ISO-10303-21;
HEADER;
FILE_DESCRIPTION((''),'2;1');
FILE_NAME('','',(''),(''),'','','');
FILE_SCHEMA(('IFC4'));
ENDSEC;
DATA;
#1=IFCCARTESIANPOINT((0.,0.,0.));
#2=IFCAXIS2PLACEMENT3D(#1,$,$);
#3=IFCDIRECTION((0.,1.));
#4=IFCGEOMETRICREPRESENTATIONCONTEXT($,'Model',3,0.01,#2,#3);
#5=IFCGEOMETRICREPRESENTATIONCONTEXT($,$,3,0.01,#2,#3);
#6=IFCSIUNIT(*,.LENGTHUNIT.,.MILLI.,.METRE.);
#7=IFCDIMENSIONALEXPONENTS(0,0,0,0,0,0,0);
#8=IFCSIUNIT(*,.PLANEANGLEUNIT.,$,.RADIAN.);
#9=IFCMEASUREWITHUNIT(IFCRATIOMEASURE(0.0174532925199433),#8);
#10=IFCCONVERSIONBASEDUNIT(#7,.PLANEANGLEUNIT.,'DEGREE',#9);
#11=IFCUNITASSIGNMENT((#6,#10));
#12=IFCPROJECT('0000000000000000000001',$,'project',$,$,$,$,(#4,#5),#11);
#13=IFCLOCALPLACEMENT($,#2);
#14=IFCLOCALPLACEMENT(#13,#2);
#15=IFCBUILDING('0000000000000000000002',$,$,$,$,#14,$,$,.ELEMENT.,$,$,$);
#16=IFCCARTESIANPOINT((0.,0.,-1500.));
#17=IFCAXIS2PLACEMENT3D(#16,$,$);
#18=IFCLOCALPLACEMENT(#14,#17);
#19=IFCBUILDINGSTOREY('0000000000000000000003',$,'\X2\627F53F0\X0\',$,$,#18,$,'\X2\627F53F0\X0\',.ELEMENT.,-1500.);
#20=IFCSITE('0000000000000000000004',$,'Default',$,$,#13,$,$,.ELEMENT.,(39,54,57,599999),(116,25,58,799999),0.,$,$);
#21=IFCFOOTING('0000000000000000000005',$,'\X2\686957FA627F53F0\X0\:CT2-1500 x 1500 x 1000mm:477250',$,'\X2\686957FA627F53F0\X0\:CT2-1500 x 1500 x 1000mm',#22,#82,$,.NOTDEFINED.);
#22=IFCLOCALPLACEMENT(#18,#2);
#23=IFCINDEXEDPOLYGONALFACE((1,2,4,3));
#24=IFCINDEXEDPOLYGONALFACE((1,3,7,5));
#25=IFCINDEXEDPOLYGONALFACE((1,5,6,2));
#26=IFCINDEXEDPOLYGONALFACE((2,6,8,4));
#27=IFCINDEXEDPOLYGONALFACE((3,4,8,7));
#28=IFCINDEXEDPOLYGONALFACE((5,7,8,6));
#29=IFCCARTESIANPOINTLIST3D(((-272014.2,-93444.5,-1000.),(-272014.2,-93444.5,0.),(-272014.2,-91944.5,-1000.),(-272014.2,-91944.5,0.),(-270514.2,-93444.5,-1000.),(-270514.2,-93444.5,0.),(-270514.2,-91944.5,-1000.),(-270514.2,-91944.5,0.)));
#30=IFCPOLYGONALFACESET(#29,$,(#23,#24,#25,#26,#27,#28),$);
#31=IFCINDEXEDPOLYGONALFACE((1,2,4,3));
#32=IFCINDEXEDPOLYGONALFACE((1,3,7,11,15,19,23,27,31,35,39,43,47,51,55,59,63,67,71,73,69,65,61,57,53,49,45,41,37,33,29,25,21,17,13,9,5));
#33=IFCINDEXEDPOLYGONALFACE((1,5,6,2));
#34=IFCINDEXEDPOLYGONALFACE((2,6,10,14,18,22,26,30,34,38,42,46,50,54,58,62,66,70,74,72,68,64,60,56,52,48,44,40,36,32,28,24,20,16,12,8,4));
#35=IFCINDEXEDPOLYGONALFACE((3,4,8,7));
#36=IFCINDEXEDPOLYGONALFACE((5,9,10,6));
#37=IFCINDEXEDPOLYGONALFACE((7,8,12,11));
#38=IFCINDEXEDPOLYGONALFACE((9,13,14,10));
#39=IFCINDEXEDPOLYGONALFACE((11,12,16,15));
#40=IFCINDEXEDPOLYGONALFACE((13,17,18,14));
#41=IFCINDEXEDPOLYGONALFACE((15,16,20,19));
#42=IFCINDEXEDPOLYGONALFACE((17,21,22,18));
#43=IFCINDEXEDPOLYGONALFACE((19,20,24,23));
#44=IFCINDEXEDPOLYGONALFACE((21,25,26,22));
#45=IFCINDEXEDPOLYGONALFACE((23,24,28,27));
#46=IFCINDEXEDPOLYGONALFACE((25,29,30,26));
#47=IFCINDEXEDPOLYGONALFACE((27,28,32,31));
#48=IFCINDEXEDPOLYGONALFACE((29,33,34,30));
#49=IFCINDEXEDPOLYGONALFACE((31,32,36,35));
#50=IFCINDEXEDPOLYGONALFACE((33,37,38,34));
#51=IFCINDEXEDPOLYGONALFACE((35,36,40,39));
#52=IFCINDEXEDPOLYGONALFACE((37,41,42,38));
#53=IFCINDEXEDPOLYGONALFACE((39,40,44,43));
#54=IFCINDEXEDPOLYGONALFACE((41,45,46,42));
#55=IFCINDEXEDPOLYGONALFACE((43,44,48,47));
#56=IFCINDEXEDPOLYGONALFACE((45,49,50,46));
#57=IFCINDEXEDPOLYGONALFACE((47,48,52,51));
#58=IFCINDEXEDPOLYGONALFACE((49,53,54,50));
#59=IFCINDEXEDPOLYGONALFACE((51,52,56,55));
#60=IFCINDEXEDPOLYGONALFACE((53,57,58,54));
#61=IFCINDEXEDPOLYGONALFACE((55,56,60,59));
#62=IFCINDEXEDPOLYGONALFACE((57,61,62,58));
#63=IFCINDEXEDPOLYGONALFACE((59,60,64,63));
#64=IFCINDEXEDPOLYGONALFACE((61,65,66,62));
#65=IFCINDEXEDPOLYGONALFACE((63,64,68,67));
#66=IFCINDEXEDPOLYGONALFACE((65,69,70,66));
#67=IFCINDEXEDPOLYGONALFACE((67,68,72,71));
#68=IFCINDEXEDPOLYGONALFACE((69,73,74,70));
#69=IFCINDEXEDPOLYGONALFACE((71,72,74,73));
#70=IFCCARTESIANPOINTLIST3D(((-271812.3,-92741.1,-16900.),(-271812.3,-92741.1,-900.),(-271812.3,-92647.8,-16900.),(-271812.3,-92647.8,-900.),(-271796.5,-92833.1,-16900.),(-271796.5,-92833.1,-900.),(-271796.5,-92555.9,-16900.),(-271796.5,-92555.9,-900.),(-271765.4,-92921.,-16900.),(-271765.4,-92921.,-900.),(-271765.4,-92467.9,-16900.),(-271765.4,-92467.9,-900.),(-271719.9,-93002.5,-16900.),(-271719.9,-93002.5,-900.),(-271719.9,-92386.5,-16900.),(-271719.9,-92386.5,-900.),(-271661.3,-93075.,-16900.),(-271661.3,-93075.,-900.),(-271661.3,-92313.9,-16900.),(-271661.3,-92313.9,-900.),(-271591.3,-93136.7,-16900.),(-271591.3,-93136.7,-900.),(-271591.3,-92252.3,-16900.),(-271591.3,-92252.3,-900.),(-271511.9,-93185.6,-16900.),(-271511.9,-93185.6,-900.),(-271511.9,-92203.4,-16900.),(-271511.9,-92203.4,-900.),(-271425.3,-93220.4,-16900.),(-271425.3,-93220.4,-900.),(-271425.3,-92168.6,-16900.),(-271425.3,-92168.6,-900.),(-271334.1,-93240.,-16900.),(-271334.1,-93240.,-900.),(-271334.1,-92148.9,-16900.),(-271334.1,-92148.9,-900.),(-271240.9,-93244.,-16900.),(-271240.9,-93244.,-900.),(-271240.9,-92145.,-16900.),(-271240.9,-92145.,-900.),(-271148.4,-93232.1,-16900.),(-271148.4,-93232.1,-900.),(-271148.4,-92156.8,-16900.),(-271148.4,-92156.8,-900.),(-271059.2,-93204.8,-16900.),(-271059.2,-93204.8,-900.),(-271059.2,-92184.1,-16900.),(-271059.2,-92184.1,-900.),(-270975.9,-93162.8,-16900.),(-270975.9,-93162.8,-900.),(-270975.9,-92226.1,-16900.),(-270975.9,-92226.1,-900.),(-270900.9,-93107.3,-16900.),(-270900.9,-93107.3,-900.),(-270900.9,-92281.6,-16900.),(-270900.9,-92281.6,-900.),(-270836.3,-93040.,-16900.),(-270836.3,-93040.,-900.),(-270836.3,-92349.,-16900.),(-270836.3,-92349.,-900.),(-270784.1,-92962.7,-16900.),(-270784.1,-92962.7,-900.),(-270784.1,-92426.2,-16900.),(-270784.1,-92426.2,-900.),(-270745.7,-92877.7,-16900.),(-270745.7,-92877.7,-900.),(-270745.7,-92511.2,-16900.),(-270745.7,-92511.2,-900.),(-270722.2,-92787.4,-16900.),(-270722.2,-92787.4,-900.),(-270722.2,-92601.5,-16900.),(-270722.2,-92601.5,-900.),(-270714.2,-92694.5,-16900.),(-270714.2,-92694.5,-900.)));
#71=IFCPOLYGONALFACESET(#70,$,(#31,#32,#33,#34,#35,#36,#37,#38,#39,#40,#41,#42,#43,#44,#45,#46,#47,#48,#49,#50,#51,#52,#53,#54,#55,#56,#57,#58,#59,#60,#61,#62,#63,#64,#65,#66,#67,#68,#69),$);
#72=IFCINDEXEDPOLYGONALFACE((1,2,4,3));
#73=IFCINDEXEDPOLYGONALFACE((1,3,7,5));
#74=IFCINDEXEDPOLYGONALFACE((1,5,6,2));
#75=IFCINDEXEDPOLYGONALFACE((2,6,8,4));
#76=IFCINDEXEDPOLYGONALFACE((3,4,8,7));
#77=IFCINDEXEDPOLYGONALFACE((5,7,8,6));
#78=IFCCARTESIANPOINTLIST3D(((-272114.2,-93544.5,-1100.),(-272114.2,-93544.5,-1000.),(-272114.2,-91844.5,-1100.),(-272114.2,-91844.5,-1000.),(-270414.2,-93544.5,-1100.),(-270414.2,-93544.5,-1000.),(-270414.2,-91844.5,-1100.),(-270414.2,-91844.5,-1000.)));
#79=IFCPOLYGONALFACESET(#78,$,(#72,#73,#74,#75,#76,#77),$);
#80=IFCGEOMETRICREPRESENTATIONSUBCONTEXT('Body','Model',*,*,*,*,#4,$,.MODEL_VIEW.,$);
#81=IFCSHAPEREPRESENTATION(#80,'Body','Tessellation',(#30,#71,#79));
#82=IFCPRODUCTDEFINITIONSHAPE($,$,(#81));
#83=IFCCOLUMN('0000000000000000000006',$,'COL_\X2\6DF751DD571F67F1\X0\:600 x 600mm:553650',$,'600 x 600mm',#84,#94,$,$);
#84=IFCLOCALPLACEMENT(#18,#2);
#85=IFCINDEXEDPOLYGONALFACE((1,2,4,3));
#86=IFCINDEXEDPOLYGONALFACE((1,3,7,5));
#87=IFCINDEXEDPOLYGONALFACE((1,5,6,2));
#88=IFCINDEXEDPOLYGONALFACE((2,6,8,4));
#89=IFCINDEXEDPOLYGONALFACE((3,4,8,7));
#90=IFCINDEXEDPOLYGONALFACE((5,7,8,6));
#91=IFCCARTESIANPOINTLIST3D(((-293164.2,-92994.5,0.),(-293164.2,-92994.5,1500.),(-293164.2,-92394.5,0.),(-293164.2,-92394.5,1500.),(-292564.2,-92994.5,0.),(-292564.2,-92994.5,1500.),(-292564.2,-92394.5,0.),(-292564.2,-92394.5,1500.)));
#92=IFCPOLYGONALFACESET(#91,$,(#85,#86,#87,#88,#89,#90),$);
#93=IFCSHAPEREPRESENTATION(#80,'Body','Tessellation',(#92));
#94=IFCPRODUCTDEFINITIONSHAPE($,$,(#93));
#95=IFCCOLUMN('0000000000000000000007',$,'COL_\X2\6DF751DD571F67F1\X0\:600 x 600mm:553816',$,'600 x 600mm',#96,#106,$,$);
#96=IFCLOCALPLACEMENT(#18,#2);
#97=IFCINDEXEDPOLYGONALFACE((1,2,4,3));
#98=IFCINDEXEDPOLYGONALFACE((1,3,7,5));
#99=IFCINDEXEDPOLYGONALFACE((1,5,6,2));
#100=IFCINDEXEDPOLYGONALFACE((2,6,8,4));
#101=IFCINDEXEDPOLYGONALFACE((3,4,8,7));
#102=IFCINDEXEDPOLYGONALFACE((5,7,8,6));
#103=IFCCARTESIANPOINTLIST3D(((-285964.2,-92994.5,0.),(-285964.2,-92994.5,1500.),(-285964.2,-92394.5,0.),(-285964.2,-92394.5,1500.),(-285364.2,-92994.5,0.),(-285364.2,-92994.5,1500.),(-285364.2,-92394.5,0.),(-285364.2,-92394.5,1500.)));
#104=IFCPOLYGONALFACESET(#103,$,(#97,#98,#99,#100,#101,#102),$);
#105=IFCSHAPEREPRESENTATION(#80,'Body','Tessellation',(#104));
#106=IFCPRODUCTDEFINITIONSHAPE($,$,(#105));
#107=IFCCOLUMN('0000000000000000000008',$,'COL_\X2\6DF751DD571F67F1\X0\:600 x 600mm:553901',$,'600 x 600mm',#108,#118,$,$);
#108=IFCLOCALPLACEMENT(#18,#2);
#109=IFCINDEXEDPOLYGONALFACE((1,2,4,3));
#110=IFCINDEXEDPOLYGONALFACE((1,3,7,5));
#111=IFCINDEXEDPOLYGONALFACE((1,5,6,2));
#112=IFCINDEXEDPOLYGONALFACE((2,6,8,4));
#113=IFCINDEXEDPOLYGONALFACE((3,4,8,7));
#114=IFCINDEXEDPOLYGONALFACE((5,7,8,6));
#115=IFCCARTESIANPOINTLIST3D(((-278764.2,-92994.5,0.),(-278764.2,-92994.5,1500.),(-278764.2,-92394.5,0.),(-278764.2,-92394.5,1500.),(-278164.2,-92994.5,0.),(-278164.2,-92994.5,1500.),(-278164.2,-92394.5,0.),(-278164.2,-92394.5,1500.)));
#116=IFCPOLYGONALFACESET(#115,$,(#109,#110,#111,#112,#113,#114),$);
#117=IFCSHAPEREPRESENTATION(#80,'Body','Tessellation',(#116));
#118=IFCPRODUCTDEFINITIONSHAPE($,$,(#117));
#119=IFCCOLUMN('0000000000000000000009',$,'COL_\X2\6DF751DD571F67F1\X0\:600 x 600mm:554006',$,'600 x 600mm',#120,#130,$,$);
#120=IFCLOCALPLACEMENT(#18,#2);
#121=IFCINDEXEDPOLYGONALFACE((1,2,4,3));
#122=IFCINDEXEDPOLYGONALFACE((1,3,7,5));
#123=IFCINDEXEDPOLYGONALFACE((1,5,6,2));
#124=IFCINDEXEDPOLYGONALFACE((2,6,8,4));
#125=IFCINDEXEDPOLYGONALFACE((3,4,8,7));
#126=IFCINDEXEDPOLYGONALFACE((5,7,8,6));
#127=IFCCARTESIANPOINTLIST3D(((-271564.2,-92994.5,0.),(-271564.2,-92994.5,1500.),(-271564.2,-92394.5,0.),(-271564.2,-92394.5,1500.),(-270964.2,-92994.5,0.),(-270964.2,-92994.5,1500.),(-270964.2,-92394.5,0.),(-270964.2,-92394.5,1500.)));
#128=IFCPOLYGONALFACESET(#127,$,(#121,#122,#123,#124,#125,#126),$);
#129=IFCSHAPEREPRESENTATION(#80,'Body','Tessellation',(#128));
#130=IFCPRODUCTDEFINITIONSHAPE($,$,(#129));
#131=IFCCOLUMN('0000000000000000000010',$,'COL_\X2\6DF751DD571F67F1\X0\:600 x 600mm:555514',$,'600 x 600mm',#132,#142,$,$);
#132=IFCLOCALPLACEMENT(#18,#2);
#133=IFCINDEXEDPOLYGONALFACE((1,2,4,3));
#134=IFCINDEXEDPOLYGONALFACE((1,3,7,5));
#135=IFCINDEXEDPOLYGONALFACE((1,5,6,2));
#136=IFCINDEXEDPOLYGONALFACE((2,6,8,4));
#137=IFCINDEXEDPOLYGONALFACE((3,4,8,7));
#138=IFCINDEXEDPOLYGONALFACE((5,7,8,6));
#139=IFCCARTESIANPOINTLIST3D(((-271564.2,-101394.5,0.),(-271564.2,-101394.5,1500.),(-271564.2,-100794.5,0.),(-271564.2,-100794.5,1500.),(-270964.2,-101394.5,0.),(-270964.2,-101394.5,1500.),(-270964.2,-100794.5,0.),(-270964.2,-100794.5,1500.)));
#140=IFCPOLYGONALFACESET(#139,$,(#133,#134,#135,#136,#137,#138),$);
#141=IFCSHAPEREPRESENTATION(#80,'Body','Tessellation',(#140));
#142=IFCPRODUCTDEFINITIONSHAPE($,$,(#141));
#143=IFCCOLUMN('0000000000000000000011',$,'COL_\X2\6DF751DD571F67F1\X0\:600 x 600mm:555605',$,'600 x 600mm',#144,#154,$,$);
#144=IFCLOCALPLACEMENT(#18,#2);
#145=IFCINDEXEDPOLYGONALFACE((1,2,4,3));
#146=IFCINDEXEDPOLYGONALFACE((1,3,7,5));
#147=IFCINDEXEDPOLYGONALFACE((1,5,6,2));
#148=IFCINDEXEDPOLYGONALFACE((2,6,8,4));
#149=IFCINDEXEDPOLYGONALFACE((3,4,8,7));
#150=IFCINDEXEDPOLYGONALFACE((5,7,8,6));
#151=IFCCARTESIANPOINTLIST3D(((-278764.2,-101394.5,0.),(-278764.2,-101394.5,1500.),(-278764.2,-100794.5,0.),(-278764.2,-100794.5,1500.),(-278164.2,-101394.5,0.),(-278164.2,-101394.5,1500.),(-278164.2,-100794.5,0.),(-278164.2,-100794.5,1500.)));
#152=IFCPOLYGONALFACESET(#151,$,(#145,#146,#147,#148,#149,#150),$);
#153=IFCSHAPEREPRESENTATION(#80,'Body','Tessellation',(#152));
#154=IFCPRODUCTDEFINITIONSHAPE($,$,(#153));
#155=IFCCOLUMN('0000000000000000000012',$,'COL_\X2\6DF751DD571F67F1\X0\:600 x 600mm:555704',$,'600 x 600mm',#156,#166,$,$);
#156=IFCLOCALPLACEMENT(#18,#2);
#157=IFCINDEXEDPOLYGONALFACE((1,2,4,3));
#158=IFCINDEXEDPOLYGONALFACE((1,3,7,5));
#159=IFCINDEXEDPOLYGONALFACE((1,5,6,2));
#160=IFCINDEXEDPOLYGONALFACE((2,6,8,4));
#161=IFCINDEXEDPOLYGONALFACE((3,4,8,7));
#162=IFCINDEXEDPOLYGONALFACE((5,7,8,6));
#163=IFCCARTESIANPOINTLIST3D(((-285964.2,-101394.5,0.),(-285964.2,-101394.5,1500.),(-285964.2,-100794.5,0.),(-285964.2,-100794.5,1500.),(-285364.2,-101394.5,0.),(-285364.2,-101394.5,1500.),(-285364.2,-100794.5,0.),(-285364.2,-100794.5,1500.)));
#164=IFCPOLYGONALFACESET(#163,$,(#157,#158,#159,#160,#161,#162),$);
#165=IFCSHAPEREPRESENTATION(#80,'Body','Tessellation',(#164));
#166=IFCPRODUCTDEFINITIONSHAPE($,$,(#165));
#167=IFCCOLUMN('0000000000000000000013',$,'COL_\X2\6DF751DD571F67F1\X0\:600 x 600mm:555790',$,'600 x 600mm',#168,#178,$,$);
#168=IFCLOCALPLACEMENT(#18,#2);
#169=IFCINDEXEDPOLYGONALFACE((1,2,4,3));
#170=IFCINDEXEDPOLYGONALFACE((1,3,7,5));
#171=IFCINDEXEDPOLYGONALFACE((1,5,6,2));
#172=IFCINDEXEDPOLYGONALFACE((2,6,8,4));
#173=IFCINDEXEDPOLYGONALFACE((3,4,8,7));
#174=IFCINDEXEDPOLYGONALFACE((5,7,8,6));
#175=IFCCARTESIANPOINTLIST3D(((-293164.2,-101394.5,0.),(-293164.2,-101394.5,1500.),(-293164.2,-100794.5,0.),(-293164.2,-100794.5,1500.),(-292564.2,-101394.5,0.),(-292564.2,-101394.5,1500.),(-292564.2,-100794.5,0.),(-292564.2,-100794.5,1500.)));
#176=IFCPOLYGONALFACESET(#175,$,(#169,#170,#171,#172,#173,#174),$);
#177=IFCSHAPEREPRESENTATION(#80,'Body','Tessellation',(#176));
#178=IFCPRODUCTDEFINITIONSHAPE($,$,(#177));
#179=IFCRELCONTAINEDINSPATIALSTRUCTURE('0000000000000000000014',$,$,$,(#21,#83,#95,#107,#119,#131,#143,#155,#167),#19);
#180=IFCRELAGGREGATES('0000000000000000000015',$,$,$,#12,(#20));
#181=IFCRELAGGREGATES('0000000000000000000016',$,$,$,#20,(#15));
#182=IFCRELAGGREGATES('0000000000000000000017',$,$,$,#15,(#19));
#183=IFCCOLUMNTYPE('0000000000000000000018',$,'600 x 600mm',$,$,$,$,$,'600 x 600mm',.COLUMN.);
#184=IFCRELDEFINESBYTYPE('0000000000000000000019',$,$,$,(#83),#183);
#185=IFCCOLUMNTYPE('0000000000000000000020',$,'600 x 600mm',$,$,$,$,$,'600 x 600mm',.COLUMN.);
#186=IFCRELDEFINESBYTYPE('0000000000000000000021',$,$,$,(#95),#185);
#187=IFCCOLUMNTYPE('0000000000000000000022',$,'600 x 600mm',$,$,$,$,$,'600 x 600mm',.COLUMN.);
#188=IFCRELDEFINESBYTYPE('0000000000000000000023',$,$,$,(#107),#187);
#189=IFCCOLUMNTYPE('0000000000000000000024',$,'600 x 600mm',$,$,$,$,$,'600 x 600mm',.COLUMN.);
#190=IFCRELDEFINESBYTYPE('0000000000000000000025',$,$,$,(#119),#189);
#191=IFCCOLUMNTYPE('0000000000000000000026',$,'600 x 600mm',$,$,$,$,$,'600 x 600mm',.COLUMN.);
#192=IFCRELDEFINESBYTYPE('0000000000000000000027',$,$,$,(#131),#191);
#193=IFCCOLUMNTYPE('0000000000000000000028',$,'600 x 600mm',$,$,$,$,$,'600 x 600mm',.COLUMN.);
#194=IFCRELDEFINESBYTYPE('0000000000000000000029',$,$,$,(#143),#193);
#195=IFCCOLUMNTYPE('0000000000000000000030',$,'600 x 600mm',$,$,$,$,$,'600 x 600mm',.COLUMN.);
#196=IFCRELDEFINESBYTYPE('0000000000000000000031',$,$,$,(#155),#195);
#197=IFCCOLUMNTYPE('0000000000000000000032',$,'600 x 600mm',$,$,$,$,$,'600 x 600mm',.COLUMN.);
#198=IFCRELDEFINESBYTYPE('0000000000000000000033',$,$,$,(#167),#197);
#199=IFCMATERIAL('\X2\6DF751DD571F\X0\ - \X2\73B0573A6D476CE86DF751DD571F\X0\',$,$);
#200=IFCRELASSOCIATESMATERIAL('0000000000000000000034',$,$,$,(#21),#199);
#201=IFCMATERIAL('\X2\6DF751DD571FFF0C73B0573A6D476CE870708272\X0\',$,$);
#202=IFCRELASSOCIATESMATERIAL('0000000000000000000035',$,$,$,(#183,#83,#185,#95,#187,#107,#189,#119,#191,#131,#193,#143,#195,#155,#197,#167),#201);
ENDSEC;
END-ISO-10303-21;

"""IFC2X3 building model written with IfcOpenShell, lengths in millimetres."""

from ifc_helpers import new_model, entity, si_unit, converted_unit, direction, frame, frame_2d, origin, origin_2d_with_axis, place, context, subcontext, project, spatial, rectangle, circle, extrude, source, transform, mapped, material, type_object, type_shapes, element, save


model = new_model("IFC2X3")

# Units and contexts
model_context = context("Model", 3, precision=0.01, world=origin(), true_north=direction((0.0, 1.0)))
context_of_model = context(None, 3, precision=0.01, world=origin(), true_north=direction((0.0, 1.0)))
body_context = subcontext(model_context, "Body", "Model", "MODEL_VIEW")
ifc_project = project(units=[si_unit("LENGTHUNIT", "METRE", prefix="MILLI"), converted_unit("PLANEANGLEUNIT", "DEGREE", entity("IfcRatioMeasure", 0.0174532925199433), si_unit("PLANEANGLEUNIT", "RADIAN"), dimensions=[0, 0, 0, 0, 0, 0, 0])], contexts=[model_context, context_of_model])

# Site, building, storey
site_placement = place(None, origin())
site = spatial("IfcSite", under=ifc_project, at=site_placement, Name="Default", CompositionType="ELEMENT", RefLatitude=(39, 54, 57, 599999), RefLongitude=(116, 25, 58, 799999), RefElevation=0.0)
building_placement = place(site_placement, origin())
building = spatial("IfcBuilding", under=site, at=building_placement, CompositionType="ELEMENT")
storey_placement = place(building_placement, frame((0.0, 0.0, -1500.0)))
storey = spatial("IfcBuildingStorey", under=building, at=storey_placement, Name="承台", LongName="承台", CompositionType="ELEMENT", Elevation=-1500.0)

# Footing
ifc_material_1 = material(Name="混凝土 - 现场浇注混凝土")
for number, where, name in (
    (1, (-272114.2, -93544.5, -16900.0), "桩基承台:CT2-1500 x 1500 x 1000mm:477250"),
):
    element("IfcFooting", number, at=place(storey_placement, frame(where)), inside=storey, material=ifc_material_1, Name=name, ObjectType="桩基承台:CT2-1500 x 1500 x 1000mm", PredefinedType="NOTDEFINED", context=body_context, shape_type="SweptSolid", body=[
        extrude(rectangle(XDim=1500.0, YDim=1500.0, at=origin_2d_with_axis()), frame((850.0, 850.0, 15900.0), z_axis=(0.0, 0.0, 1.0), x_axis=(-1.0, 0.0, 0.0)), (0.0, 0.0, 1.0), 1000.0),
        extrude(circle(Radius=550.0, at=origin_2d_with_axis()), frame((850.0, 850.0, 0.0)), (0.0, 0.0, 1.0), 16000.0),
        extrude(rectangle(XDim=1700.0, YDim=1700.0, at=frame_2d((0.0, 0.0), x_axis=(1.0, 0.0))), frame((850.0, 850.0, 15800.0), z_axis=(0.0, 0.0, 1.0), x_axis=(0.0, 1.0, 0.0)), (0.0, 0.0, 1.0), 100.0),
    ])

# Columns
ifc_material_2 = material(Name="混凝土，现场浇注灰色")
column_type_1 = type_object("IfcColumnType", Name="600 x 600mm", ElementType="600 x 600mm", PredefinedType="COLUMN", material=ifc_material_2)
shared_shape_1 = source(origin(), body_context, "Body", "SweptSolid", [
    extrude(rectangle(XDim=600.0, YDim=600.0, at=origin_2d_with_axis()), frame((300.0, 300.0, 0.0), z_axis=(0.0, 0.0, 1.0), x_axis=(-1.0, 0.0, 0.0)), (0.0, 0.0, 1.0), 1500.0),
])
type_shapes(column_type_1, [shared_shape_1])
column_1_placement = place(storey_placement, frame((-293164.2, -92994.5, 0.0)))
element("IfcColumn", 2, at=column_1_placement, inside=storey, type_object=column_type_1, material=ifc_material_2, Name="COL_混凝土柱:600 x 600mm:553650", ObjectType="600 x 600mm", context=body_context, shape_type="MappedRepresentation", body=[
    mapped(shared_shape_1, transform((0.0, 0.0, 0.0), scale=1.0)),
])
column_type_2 = type_object("IfcColumnType", Name="600 x 600mm", ElementType="600 x 600mm", PredefinedType="COLUMN", material=ifc_material_2)
shared_shape_2 = source(origin(), body_context, "Body", "SweptSolid", [
    extrude(rectangle(XDim=600.0, YDim=600.0, at=origin_2d_with_axis()), frame((300.0, 300.0, 0.0), z_axis=(0.0, 0.0, 1.0), x_axis=(-1.0, 0.0, 0.0)), (0.0, 0.0, 1.0), 1500.0),
])
type_shapes(column_type_2, [shared_shape_2])
column_2_placement = place(storey_placement, frame((-285964.2, -92994.5, 0.0)))
element("IfcColumn", 3, at=column_2_placement, inside=storey, type_object=column_type_2, material=ifc_material_2, Name="COL_混凝土柱:600 x 600mm:553816", ObjectType="600 x 600mm", context=body_context, shape_type="MappedRepresentation", body=[
    mapped(shared_shape_2, transform((0.0, 0.0, 0.0), scale=1.0)),
])
column_type_3 = type_object("IfcColumnType", Name="600 x 600mm", ElementType="600 x 600mm", PredefinedType="COLUMN", material=ifc_material_2)
shared_shape_3 = source(origin(), body_context, "Body", "SweptSolid", [
    extrude(rectangle(XDim=600.0, YDim=600.0, at=origin_2d_with_axis()), frame((300.0, 300.0, 0.0), z_axis=(0.0, 0.0, 1.0), x_axis=(-1.0, 0.0, 0.0)), (0.0, 0.0, 1.0), 1500.0),
])
type_shapes(column_type_3, [shared_shape_3])
column_3_placement = place(storey_placement, frame((-278764.2, -92994.5, 0.0)))
element("IfcColumn", 4, at=column_3_placement, inside=storey, type_object=column_type_3, material=ifc_material_2, Name="COL_混凝土柱:600 x 600mm:553901", ObjectType="600 x 600mm", context=body_context, shape_type="MappedRepresentation", body=[
    mapped(shared_shape_3, transform((0.0, 0.0, 0.0), scale=1.0)),
])
column_type_4 = type_object("IfcColumnType", Name="600 x 600mm", ElementType="600 x 600mm", PredefinedType="COLUMN", material=ifc_material_2)
shared_shape_4 = source(origin(), body_context, "Body", "SweptSolid", [
    extrude(rectangle(XDim=600.0, YDim=600.0, at=origin_2d_with_axis()), frame((300.0, 300.0, 0.0), z_axis=(0.0, 0.0, 1.0), x_axis=(-1.0, 0.0, 0.0)), (0.0, 0.0, 1.0), 1500.0),
])
type_shapes(column_type_4, [shared_shape_4])
column_4_placement = place(storey_placement, frame((-271564.2, -92994.5, 0.0)))
element("IfcColumn", 5, at=column_4_placement, inside=storey, type_object=column_type_4, material=ifc_material_2, Name="COL_混凝土柱:600 x 600mm:554006", ObjectType="600 x 600mm", context=body_context, shape_type="MappedRepresentation", body=[
    mapped(shared_shape_4, transform((0.0, 0.0, 0.0), scale=1.0)),
])
column_type_5 = type_object("IfcColumnType", Name="600 x 600mm", ElementType="600 x 600mm", PredefinedType="COLUMN", material=ifc_material_2)
shared_shape_5 = source(origin(), body_context, "Body", "SweptSolid", [
    extrude(rectangle(XDim=600.0, YDim=600.0, at=origin_2d_with_axis()), frame((300.0, 300.0, 0.0), z_axis=(0.0, 0.0, 1.0), x_axis=(-1.0, 0.0, 0.0)), (0.0, 0.0, 1.0), 1500.0),
])
type_shapes(column_type_5, [shared_shape_5])
column_5_placement = place(storey_placement, frame((-271564.2, -101394.5, 0.0)))
element("IfcColumn", 6, at=column_5_placement, inside=storey, type_object=column_type_5, material=ifc_material_2, Name="COL_混凝土柱:600 x 600mm:555514", ObjectType="600 x 600mm", context=body_context, shape_type="MappedRepresentation", body=[
    mapped(shared_shape_5, transform((0.0, 0.0, 0.0), scale=1.0)),
])
column_type_6 = type_object("IfcColumnType", Name="600 x 600mm", ElementType="600 x 600mm", PredefinedType="COLUMN", material=ifc_material_2)
shared_shape_6 = source(origin(), body_context, "Body", "SweptSolid", [
    extrude(rectangle(XDim=600.0, YDim=600.0, at=origin_2d_with_axis()), frame((300.0, 300.0, 0.0), z_axis=(0.0, 0.0, 1.0), x_axis=(-1.0, 0.0, 0.0)), (0.0, 0.0, 1.0), 1500.0),
])
type_shapes(column_type_6, [shared_shape_6])
column_6_placement = place(storey_placement, frame((-278764.2, -101394.5, 0.0)))
element("IfcColumn", 7, at=column_6_placement, inside=storey, type_object=column_type_6, material=ifc_material_2, Name="COL_混凝土柱:600 x 600mm:555605", ObjectType="600 x 600mm", context=body_context, shape_type="MappedRepresentation", body=[
    mapped(shared_shape_6, transform((0.0, 0.0, 0.0), scale=1.0)),
])
column_type_7 = type_object("IfcColumnType", Name="600 x 600mm", ElementType="600 x 600mm", PredefinedType="COLUMN", material=ifc_material_2)
shared_shape_7 = source(origin(), body_context, "Body", "SweptSolid", [
    extrude(rectangle(XDim=600.0, YDim=600.0, at=origin_2d_with_axis()), frame((300.0, 300.0, 0.0), z_axis=(0.0, 0.0, 1.0), x_axis=(-1.0, 0.0, 0.0)), (0.0, 0.0, 1.0), 1500.0),
])
type_shapes(column_type_7, [shared_shape_7])
column_7_placement = place(storey_placement, frame((-285964.2, -101394.5, 0.0)))
element("IfcColumn", 8, at=column_7_placement, inside=storey, type_object=column_type_7, material=ifc_material_2, Name="COL_混凝土柱:600 x 600mm:555704", ObjectType="600 x 600mm", context=body_context, shape_type="MappedRepresentation", body=[
    mapped(shared_shape_7, transform((0.0, 0.0, 0.0), scale=1.0)),
])
column_type_8 = type_object("IfcColumnType", Name="600 x 600mm", ElementType="600 x 600mm", PredefinedType="COLUMN", material=ifc_material_2)
shared_shape_8 = source(origin(), body_context, "Body", "SweptSolid", [
    extrude(rectangle(XDim=600.0, YDim=600.0, at=origin_2d_with_axis()), frame((300.0, 300.0, 0.0), z_axis=(0.0, 0.0, 1.0), x_axis=(-1.0, 0.0, 0.0)), (0.0, 0.0, 1.0), 1500.0),
])
type_shapes(column_type_8, [shared_shape_8])
column_8_placement = place(storey_placement, frame((-293164.2, -101394.5, 0.0)))
element("IfcColumn", 9, at=column_8_placement, inside=storey, type_object=column_type_8, material=ifc_material_2, Name="COL_混凝土柱:600 x 600mm:555790", ObjectType="600 x 600mm", context=body_context, shape_type="MappedRepresentation", body=[
    mapped(shared_shape_8, transform((0.0, 0.0, 0.0), scale=1.0)),
])

save(model, "model.ifc")
